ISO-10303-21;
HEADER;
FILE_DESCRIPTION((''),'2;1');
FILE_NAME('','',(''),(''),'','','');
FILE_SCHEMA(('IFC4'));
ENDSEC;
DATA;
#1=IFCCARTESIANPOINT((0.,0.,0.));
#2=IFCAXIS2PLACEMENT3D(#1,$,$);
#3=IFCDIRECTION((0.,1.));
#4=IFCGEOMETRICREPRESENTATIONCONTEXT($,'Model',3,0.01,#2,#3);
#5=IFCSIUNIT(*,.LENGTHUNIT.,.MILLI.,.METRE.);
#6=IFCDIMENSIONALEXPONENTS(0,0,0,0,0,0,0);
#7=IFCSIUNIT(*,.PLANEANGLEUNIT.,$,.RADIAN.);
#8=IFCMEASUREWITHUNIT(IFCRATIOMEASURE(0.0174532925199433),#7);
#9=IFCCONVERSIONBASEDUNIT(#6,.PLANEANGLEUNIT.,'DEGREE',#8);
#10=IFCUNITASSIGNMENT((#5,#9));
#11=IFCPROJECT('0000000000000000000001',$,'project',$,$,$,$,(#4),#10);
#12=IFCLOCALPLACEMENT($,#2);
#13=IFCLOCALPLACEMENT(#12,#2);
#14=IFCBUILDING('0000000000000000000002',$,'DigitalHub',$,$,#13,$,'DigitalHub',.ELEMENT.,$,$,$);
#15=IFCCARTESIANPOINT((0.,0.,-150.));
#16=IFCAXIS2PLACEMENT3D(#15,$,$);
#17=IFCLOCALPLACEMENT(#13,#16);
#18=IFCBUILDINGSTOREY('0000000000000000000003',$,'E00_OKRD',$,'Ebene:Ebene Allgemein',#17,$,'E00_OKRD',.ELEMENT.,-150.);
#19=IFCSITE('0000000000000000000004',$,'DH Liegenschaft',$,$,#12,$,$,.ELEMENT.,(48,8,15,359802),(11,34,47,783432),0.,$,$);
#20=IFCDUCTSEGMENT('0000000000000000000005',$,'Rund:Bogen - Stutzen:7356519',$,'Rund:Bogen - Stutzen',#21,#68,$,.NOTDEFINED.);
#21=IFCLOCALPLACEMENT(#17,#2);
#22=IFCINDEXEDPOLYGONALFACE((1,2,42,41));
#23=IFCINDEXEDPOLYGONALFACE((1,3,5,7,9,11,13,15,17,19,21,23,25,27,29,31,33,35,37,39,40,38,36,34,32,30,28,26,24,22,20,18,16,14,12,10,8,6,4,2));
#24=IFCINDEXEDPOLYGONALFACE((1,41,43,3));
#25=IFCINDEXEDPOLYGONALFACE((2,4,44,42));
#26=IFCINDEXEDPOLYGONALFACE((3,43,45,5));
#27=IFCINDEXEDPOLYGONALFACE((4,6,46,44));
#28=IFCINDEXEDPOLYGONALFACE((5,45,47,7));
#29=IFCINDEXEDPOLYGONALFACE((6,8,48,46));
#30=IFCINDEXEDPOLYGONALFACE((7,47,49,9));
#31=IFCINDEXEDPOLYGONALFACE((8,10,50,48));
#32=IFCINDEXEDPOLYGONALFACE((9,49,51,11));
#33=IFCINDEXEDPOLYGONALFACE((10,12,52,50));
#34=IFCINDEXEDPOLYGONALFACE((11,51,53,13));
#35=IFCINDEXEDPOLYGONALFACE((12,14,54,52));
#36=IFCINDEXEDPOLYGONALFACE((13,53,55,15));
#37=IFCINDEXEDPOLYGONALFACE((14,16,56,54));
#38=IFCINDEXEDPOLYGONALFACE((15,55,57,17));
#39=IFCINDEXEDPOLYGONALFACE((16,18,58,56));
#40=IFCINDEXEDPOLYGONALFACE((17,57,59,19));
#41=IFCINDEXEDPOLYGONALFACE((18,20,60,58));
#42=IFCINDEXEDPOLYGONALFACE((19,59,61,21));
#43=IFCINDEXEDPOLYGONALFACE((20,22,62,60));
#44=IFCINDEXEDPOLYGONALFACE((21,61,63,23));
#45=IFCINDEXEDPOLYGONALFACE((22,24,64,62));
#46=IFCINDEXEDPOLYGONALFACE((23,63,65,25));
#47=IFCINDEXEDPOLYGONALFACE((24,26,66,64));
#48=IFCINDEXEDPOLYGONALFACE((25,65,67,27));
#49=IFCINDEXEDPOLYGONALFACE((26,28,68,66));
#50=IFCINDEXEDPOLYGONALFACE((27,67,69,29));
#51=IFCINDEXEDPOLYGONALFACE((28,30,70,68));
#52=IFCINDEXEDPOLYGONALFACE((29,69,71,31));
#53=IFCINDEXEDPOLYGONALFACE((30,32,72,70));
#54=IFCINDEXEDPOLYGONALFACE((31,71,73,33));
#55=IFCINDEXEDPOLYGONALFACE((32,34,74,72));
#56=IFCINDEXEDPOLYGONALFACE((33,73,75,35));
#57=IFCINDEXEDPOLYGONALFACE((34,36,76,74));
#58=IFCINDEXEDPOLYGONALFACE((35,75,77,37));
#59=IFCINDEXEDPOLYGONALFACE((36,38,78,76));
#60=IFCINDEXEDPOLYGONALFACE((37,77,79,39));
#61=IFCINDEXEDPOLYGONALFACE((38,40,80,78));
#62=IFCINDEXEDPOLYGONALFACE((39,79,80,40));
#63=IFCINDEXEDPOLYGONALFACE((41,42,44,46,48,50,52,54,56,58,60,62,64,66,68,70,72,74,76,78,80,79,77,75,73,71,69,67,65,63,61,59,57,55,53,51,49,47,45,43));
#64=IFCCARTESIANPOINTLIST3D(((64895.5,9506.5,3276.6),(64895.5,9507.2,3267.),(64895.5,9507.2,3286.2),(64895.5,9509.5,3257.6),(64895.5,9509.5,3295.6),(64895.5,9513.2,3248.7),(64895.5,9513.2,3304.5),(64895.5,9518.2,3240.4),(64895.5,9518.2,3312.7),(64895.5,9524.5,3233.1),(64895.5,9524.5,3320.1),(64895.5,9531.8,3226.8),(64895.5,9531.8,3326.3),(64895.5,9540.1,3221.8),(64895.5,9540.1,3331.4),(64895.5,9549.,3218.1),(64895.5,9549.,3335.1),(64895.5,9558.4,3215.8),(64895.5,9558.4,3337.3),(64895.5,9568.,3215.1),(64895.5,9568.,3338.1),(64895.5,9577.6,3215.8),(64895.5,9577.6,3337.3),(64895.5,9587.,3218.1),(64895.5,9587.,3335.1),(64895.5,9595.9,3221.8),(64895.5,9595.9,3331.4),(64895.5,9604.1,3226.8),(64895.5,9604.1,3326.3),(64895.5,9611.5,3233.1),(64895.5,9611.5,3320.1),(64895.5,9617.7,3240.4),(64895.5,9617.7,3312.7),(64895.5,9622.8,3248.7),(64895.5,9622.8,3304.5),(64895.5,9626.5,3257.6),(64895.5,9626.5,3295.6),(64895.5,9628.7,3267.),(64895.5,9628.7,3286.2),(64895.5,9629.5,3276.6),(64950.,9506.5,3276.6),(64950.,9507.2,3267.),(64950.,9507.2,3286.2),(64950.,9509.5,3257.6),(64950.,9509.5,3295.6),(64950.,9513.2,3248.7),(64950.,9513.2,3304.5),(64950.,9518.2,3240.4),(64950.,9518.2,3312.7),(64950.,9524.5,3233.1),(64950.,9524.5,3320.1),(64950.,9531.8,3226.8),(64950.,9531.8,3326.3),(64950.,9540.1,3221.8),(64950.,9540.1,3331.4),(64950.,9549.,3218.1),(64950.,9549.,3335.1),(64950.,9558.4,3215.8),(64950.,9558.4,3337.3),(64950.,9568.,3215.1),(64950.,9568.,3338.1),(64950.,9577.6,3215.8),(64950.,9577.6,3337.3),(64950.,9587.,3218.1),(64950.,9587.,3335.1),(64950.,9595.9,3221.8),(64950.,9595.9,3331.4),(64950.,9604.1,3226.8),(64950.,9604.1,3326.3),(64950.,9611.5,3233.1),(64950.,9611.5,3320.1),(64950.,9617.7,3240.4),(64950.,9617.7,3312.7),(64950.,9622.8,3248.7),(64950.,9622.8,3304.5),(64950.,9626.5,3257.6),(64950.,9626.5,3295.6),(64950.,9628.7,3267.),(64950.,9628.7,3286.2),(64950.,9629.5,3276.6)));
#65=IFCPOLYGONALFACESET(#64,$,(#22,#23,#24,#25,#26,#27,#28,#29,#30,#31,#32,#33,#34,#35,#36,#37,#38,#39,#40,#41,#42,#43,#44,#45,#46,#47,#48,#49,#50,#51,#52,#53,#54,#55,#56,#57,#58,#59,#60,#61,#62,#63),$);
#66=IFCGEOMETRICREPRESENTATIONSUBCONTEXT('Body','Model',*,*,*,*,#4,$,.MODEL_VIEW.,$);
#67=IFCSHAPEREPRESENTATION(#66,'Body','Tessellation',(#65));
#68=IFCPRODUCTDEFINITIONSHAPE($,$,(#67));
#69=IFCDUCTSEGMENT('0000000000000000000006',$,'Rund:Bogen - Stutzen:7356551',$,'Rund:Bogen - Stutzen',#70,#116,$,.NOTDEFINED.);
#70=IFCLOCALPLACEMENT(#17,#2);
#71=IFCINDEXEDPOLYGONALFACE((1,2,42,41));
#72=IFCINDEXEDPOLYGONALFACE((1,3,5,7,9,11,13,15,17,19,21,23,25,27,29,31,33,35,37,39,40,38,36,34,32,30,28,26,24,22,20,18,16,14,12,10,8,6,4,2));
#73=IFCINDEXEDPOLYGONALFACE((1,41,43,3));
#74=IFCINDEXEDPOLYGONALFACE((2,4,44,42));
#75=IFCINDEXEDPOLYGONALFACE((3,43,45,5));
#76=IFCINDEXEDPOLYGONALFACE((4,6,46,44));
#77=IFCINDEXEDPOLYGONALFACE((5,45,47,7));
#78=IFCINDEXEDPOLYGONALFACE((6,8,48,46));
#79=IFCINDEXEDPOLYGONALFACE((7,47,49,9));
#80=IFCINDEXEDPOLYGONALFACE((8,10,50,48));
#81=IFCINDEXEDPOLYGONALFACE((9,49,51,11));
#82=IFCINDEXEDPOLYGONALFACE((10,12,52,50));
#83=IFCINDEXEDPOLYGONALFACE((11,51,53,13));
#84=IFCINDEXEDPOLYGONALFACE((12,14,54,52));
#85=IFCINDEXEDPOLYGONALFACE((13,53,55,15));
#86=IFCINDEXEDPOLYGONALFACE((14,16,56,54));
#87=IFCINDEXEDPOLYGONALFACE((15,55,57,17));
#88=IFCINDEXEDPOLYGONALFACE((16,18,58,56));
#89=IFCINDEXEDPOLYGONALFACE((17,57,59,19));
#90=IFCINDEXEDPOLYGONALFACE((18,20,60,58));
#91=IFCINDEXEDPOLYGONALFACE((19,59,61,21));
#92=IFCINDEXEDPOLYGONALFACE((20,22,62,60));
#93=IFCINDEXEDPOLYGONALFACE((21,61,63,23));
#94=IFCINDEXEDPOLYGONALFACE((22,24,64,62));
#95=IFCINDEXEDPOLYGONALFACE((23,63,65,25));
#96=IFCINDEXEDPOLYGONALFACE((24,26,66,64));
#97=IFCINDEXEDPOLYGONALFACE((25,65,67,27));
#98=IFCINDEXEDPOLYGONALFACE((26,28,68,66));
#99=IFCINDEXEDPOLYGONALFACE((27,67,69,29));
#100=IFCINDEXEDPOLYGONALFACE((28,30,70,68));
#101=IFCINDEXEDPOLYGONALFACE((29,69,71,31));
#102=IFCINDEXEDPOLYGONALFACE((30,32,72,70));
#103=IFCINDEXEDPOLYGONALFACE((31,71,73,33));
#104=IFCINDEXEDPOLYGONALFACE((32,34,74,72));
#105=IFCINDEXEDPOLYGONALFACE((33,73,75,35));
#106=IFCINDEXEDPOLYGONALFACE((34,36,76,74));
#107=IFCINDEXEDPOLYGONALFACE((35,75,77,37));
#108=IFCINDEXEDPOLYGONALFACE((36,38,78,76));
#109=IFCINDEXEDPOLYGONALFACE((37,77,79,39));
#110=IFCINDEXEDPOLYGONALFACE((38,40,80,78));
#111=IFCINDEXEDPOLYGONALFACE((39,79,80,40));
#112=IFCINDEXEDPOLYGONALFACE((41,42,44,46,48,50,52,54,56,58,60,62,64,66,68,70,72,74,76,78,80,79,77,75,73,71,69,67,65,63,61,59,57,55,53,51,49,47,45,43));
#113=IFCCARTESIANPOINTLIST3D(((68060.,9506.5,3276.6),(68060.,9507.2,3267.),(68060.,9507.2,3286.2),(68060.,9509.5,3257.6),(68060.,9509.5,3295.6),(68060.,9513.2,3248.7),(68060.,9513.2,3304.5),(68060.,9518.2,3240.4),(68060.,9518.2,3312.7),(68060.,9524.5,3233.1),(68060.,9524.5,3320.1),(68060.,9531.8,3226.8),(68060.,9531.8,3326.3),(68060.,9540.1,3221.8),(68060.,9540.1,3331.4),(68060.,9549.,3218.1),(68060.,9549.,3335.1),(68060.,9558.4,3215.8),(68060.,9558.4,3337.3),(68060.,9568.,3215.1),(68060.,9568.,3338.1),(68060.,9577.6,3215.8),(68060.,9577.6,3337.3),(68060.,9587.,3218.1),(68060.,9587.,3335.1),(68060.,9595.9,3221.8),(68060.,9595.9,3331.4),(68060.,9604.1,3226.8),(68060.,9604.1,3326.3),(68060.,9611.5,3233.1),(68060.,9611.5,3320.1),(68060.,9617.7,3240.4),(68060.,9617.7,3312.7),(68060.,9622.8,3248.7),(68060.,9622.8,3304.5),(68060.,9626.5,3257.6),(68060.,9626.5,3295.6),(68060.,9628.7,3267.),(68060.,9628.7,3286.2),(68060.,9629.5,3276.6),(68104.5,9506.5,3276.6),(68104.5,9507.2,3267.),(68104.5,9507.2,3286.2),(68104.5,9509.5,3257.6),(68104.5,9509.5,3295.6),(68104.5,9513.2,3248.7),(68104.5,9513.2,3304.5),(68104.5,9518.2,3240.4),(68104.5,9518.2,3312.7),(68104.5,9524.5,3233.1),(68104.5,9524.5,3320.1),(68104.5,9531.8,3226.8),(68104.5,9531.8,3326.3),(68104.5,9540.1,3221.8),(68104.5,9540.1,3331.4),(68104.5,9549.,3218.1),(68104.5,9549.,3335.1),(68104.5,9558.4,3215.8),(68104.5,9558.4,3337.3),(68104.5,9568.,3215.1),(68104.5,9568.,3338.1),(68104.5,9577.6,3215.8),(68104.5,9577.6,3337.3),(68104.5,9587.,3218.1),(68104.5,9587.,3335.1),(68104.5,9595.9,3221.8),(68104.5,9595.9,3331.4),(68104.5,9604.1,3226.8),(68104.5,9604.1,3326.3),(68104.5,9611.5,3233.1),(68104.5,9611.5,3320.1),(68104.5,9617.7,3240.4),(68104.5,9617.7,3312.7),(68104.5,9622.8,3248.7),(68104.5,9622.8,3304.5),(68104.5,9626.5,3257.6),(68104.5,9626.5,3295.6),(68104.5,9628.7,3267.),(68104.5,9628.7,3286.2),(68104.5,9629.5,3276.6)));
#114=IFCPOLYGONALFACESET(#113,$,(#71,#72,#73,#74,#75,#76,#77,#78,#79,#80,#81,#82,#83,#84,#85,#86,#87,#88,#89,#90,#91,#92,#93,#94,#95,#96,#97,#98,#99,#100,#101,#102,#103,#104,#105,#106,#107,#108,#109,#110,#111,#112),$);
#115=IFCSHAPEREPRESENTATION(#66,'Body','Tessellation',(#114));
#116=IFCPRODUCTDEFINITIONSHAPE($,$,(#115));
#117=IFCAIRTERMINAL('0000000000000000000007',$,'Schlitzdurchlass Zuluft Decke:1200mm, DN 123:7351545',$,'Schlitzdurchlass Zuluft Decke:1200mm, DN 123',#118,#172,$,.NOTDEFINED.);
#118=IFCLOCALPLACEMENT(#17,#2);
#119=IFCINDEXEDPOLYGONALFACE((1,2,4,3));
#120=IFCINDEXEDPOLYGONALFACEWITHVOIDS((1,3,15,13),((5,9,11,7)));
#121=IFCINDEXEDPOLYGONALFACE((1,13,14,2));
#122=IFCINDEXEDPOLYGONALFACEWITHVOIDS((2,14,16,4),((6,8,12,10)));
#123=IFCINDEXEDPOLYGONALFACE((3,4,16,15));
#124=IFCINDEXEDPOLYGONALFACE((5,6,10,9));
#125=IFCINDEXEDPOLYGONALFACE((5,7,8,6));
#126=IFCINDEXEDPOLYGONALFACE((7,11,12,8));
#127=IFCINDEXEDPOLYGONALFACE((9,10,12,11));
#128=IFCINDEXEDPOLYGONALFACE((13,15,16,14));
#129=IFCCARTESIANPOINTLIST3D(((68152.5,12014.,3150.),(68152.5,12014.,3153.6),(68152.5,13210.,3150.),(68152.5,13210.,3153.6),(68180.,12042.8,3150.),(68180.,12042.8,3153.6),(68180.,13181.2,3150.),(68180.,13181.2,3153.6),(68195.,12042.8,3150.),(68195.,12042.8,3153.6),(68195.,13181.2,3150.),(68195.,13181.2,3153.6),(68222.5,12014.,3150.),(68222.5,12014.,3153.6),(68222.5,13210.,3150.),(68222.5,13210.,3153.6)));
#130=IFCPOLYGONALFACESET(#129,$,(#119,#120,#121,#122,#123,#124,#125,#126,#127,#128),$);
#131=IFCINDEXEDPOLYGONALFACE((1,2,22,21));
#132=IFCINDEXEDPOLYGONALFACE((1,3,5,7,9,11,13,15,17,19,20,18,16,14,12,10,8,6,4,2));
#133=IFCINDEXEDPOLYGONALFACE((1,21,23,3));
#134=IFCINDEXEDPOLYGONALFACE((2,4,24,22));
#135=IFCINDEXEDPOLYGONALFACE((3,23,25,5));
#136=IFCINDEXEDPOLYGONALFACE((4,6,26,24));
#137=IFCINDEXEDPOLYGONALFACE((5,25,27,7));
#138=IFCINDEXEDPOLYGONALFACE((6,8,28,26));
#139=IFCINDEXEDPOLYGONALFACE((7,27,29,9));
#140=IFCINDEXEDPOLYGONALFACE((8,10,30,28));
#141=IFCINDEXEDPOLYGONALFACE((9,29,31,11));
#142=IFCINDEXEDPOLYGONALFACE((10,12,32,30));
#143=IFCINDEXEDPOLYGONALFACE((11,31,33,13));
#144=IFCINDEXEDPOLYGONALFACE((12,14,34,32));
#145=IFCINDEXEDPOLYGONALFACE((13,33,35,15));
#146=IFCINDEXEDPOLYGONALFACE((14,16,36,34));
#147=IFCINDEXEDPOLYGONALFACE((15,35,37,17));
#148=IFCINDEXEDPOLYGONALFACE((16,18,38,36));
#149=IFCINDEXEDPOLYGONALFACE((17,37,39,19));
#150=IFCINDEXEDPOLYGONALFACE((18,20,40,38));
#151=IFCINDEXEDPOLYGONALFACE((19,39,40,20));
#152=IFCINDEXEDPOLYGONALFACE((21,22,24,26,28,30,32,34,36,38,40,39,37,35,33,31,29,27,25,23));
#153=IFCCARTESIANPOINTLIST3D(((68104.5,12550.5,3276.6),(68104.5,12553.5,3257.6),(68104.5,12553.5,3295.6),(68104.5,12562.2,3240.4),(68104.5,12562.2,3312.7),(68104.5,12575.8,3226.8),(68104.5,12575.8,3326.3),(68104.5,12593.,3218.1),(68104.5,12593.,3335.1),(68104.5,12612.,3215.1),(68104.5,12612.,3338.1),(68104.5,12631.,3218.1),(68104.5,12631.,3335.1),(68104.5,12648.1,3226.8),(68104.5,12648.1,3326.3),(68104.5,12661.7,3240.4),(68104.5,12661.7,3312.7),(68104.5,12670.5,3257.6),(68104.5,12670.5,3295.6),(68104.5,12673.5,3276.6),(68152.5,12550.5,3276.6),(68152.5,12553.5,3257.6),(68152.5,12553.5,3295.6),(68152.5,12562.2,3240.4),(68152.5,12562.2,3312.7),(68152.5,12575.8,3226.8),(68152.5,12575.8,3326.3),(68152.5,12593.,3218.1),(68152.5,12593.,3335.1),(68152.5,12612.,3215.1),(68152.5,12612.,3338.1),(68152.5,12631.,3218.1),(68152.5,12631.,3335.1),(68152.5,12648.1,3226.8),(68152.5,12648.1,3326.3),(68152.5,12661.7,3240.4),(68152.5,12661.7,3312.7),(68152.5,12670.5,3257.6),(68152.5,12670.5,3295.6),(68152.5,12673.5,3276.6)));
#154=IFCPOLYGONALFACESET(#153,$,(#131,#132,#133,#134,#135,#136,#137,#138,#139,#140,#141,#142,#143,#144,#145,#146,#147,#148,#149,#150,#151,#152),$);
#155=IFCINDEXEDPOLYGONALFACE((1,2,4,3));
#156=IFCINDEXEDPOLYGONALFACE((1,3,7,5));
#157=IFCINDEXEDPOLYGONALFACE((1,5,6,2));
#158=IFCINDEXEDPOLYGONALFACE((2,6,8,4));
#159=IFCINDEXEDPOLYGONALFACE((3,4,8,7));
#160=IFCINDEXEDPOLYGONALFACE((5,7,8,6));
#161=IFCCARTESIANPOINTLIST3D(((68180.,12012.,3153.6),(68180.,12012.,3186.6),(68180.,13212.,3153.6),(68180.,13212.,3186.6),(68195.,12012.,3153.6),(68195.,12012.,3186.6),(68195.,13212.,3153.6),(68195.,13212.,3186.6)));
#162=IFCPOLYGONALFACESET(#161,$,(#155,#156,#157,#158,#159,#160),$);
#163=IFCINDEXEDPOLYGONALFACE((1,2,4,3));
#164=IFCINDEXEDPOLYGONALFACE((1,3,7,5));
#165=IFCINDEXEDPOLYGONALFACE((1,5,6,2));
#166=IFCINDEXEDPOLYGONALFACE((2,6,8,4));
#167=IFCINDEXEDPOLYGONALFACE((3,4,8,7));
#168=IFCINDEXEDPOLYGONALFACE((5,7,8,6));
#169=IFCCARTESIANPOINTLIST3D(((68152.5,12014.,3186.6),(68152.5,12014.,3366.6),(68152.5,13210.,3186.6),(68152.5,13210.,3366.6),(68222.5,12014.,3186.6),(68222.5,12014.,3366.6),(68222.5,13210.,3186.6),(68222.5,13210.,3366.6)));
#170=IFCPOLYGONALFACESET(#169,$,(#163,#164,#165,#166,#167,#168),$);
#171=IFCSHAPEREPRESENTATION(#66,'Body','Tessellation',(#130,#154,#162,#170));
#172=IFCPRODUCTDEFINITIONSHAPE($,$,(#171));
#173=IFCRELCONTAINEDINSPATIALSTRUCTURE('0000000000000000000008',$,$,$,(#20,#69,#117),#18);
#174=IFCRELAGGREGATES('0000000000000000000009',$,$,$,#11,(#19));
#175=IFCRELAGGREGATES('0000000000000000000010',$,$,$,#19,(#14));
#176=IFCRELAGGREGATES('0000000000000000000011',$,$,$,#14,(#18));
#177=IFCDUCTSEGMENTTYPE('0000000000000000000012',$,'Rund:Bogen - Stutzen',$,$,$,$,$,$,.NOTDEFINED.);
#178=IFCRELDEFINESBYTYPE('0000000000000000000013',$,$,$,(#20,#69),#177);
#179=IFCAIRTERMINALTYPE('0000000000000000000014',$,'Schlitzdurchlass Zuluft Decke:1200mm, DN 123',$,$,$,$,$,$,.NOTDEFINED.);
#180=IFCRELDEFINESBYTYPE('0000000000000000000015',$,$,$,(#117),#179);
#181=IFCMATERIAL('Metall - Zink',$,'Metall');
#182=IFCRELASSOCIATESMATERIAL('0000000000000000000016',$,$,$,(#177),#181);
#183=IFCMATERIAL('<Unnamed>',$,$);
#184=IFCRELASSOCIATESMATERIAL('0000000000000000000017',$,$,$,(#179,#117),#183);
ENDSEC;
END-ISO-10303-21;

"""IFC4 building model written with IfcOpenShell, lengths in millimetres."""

from ifc_helpers import new_model, entity, si_unit, converted_unit, direction, frame, origin, place, context, subcontext, project, spatial, indexed_curve, outline, extrude, source, transform, mapped, material, type_object, type_shapes, element, save


model = new_model("IFC4")

# Units and contexts
model_context = context("Model", 3, precision=0.01, world=origin(), true_north=direction((0.0, 1.0)))
body_context = subcontext(model_context, "Body", "Model", "MODEL_VIEW")
ifc_project = project(units=[si_unit("LENGTHUNIT", "METRE", prefix="MILLI"), converted_unit("PLANEANGLEUNIT", "DEGREE", entity("IfcRatioMeasure", 0.0174532925199433), si_unit("PLANEANGLEUNIT", "RADIAN"), dimensions=[0, 0, 0, 0, 0, 0, 0])], contexts=[model_context])

# Site, building, storey
site_placement = place(None, origin())
site = spatial("IfcSite", under=ifc_project, at=site_placement, Name="DH Liegenschaft", CompositionType="ELEMENT", RefLatitude=(48, 8, 15, 359802), RefLongitude=(11, 34, 47, 783432), RefElevation=0.0)
building_placement = place(site_placement, origin())
building = spatial("IfcBuilding", under=site, at=building_placement, Name="DigitalHub", LongName="DigitalHub", CompositionType="ELEMENT")
storey_placement = place(building_placement, frame((0.0, 0.0, -150.0)))
storey = spatial("IfcBuildingStorey", under=building, at=storey_placement, Name="E00_OKRD", ObjectType="Ebene:Ebene Allgemein", LongName="E00_OKRD", CompositionType="ELEMENT", Elevation=-150.0)

# Duct segments
ifc_material_1 = material(Name="Metall - Zink", Category="Metall")
duct_segment_type_1 = type_object("IfcDuctSegmentType", Name="Rund:Bogen - Stutzen", PredefinedType="NOTDEFINED", material=ifc_material_1)
duct_segment_1_placement = place(storey_placement, frame((64895.5, 9504.9, 3213.5)))
element("IfcDuctSegment", 1, at=duct_segment_1_placement, inside=storey, type_object=duct_segment_type_1, Name="Rund:Bogen - Stutzen:7356519", ObjectType="Rund:Bogen - Stutzen", PredefinedType="NOTDEFINED", context=body_context, shape_type="SweptSolid", body=[
    extrude(outline(indexed_curve([(61.5, 0.0), (60.7, 9.6), (58.5, 19.0), (54.8, 27.9), (49.8, 36.1), (43.5, 43.5), (36.1, 49.8), (27.9, 54.8), (19.0, 58.5), (9.6, 60.7), (0.0, 61.5), (-9.6, 60.7), (-19.0, 58.5), (-27.9, 54.8), (-36.1, 49.8), (-43.5, 43.5), (-49.8, 36.1), (-54.8, 27.9), (-58.5, 19.0), (-60.7, 9.6), (-61.5, 0.0), (-60.7, -9.6), (-58.5, -19.0), (-54.8, -27.9), (-49.8, -36.1), (-43.5, -43.5), (-36.1, -49.8), (-27.9, -54.8), (-19.0, -58.5), (-9.6, -60.7), (0.0, -61.5), (9.6, -60.7), (19.0, -58.5), (27.9, -54.8), (36.1, -49.8), (43.5, -43.5), (49.8, -36.1), (54.8, -27.9), (58.5, -19.0), (60.7, -9.6), (61.5, 0.0)], self_intersect=False)), frame((0.0, 63.1, 63.1), z_axis=(1.0, 0.0, 0.0), x_axis=(0.0, 1.0, 0.0)), (0.0, 0.0, 1.0), 54.5),
])
duct_segment_2_placement = place(storey_placement, frame((68060.0, 9504.9, 3213.5)))
element("IfcDuctSegment", 2, at=duct_segment_2_placement, inside=storey, type_object=duct_segment_type_1, Name="Rund:Bogen - Stutzen:7356551", ObjectType="Rund:Bogen - Stutzen", PredefinedType="NOTDEFINED", context=body_context, shape_type="SweptSolid", body=[
    extrude(outline(indexed_curve([(61.5, 0.0), (60.7, 9.6), (58.5, 19.0), (54.8, 27.9), (49.8, 36.1), (43.5, 43.5), (36.1, 49.8), (27.9, 54.8), (19.0, 58.5), (9.6, 60.7), (0.0, 61.5), (-9.6, 60.7), (-19.0, 58.5), (-27.9, 54.8), (-36.1, 49.8), (-43.5, 43.5), (-49.8, 36.1), (-54.8, 27.9), (-58.5, 19.0), (-60.7, 9.6), (-61.5, 0.0), (-60.7, -9.6), (-58.5, -19.0), (-54.8, -27.9), (-49.8, -36.1), (-43.5, -43.5), (-36.1, -49.8), (-27.9, -54.8), (-19.0, -58.5), (-9.6, -60.7), (0.0, -61.5), (9.6, -60.7), (19.0, -58.5), (27.9, -54.8), (36.1, -49.8), (43.5, -43.5), (49.8, -36.1), (54.8, -27.9), (58.5, -19.0), (60.7, -9.6), (61.5, 0.0)], self_intersect=False)), frame((0.0, 63.1, 63.1), z_axis=(1.0, 0.0, 0.0), x_axis=(0.0, -1.0, 0.0)), (0.0, 0.0, 1.0), 44.5),
])

# Air terminal
ifc_material_2 = material(Name="<Unnamed>")
air_terminal_type = type_object("IfcAirTerminalType", Name="Schlitzdurchlass Zuluft Decke:1200mm, DN 123", PredefinedType="NOTDEFINED", material=ifc_material_2)
shared_shape_1 = source(origin(), body_context, "Body", "SweptSolid", [
    extrude(outline(indexed_curve([(-598.0, -35.0), (598.0, -35.0), (598.0, 35.0), (-598.0, 35.0), (-598.0, -35.0)], self_intersect=False), holes=[indexed_curve([(-569.2, -7.5), (-569.2, 7.5), (569.2, 7.5), (569.2, -7.5), (-569.2, -7.5)], self_intersect=False)]), frame((600.0, 35.0, 0.0), z_axis=(0.0, 0.0, 1.0), x_axis=(-1.0, 0.0, 0.0)), (0.0, 0.0, 1.0), 3.6),
    extrude(outline(indexed_curve([(61.5, 0.0), (58.5, 19.0), (49.8, 36.1), (36.1, 49.8), (19.0, 58.5), (0.0, 61.5), (-19.0, 58.5), (-36.1, 49.8), (-49.8, 36.1), (-58.5, 19.0), (-61.5, 0.0), (-58.5, -19.0), (-49.8, -36.1), (-36.1, -49.8), (-19.0, -58.5), (0.0, -61.5), (19.0, -58.5), (36.1, -49.8), (49.8, -36.1), (58.5, -19.0), (61.5, 0.0)], self_intersect=False)), frame((600.0, 70.0, 126.6), z_axis=(0.0, 1.0, 0.0), x_axis=(-1.0, 0.0, 0.0)), (0.0, 0.0, 1.0), 48.0),
    extrude(outline(indexed_curve([(-600.0, -7.5), (600.0, -7.5), (600.0, 7.5), (-600.0, 7.5), (-600.0, -7.5)], self_intersect=False)), frame((600.0, 35.0, 3.6), z_axis=(0.0, 0.0, 1.0), x_axis=(-1.0, 0.0, 0.0)), (0.0, 0.0, 1.0), 33.0),
    extrude(outline(indexed_curve([(-598.0, -35.0), (598.0, -35.0), (598.0, 35.0), (-598.0, 35.0), (-598.0, -35.0)], self_intersect=False)), frame((600.0, 35.0, 36.6), z_axis=(0.0, 0.0, 1.0), x_axis=(-1.0, 0.0, 0.0)), (0.0, 0.0, 1.0), 180.0),
])
type_shapes(air_terminal_type, [shared_shape_1])
for number, where, z_axis, x_axis, name in (
    (3, (68222.5, 12012.0, 3150.0), (0.0, 0.0, 1.0), (0.0, 1.0, 0.0), "Schlitzdurchlass Zuluft Decke:1200mm, DN 123:7351545"),
):
    element("IfcAirTerminal", number, at=place(storey_placement, frame(where, z_axis=z_axis, x_axis=x_axis)), inside=storey, type_object=air_terminal_type, material=ifc_material_2, Name=name, ObjectType="Schlitzdurchlass Zuluft Decke:1200mm, DN 123", PredefinedType="NOTDEFINED", context=body_context, shape_type="MappedRepresentation", body=[
        mapped(shared_shape_1, transform((0.0, 0.0, 0.0), scale=1.0)),
    ])

save(model, "model.ifc")
